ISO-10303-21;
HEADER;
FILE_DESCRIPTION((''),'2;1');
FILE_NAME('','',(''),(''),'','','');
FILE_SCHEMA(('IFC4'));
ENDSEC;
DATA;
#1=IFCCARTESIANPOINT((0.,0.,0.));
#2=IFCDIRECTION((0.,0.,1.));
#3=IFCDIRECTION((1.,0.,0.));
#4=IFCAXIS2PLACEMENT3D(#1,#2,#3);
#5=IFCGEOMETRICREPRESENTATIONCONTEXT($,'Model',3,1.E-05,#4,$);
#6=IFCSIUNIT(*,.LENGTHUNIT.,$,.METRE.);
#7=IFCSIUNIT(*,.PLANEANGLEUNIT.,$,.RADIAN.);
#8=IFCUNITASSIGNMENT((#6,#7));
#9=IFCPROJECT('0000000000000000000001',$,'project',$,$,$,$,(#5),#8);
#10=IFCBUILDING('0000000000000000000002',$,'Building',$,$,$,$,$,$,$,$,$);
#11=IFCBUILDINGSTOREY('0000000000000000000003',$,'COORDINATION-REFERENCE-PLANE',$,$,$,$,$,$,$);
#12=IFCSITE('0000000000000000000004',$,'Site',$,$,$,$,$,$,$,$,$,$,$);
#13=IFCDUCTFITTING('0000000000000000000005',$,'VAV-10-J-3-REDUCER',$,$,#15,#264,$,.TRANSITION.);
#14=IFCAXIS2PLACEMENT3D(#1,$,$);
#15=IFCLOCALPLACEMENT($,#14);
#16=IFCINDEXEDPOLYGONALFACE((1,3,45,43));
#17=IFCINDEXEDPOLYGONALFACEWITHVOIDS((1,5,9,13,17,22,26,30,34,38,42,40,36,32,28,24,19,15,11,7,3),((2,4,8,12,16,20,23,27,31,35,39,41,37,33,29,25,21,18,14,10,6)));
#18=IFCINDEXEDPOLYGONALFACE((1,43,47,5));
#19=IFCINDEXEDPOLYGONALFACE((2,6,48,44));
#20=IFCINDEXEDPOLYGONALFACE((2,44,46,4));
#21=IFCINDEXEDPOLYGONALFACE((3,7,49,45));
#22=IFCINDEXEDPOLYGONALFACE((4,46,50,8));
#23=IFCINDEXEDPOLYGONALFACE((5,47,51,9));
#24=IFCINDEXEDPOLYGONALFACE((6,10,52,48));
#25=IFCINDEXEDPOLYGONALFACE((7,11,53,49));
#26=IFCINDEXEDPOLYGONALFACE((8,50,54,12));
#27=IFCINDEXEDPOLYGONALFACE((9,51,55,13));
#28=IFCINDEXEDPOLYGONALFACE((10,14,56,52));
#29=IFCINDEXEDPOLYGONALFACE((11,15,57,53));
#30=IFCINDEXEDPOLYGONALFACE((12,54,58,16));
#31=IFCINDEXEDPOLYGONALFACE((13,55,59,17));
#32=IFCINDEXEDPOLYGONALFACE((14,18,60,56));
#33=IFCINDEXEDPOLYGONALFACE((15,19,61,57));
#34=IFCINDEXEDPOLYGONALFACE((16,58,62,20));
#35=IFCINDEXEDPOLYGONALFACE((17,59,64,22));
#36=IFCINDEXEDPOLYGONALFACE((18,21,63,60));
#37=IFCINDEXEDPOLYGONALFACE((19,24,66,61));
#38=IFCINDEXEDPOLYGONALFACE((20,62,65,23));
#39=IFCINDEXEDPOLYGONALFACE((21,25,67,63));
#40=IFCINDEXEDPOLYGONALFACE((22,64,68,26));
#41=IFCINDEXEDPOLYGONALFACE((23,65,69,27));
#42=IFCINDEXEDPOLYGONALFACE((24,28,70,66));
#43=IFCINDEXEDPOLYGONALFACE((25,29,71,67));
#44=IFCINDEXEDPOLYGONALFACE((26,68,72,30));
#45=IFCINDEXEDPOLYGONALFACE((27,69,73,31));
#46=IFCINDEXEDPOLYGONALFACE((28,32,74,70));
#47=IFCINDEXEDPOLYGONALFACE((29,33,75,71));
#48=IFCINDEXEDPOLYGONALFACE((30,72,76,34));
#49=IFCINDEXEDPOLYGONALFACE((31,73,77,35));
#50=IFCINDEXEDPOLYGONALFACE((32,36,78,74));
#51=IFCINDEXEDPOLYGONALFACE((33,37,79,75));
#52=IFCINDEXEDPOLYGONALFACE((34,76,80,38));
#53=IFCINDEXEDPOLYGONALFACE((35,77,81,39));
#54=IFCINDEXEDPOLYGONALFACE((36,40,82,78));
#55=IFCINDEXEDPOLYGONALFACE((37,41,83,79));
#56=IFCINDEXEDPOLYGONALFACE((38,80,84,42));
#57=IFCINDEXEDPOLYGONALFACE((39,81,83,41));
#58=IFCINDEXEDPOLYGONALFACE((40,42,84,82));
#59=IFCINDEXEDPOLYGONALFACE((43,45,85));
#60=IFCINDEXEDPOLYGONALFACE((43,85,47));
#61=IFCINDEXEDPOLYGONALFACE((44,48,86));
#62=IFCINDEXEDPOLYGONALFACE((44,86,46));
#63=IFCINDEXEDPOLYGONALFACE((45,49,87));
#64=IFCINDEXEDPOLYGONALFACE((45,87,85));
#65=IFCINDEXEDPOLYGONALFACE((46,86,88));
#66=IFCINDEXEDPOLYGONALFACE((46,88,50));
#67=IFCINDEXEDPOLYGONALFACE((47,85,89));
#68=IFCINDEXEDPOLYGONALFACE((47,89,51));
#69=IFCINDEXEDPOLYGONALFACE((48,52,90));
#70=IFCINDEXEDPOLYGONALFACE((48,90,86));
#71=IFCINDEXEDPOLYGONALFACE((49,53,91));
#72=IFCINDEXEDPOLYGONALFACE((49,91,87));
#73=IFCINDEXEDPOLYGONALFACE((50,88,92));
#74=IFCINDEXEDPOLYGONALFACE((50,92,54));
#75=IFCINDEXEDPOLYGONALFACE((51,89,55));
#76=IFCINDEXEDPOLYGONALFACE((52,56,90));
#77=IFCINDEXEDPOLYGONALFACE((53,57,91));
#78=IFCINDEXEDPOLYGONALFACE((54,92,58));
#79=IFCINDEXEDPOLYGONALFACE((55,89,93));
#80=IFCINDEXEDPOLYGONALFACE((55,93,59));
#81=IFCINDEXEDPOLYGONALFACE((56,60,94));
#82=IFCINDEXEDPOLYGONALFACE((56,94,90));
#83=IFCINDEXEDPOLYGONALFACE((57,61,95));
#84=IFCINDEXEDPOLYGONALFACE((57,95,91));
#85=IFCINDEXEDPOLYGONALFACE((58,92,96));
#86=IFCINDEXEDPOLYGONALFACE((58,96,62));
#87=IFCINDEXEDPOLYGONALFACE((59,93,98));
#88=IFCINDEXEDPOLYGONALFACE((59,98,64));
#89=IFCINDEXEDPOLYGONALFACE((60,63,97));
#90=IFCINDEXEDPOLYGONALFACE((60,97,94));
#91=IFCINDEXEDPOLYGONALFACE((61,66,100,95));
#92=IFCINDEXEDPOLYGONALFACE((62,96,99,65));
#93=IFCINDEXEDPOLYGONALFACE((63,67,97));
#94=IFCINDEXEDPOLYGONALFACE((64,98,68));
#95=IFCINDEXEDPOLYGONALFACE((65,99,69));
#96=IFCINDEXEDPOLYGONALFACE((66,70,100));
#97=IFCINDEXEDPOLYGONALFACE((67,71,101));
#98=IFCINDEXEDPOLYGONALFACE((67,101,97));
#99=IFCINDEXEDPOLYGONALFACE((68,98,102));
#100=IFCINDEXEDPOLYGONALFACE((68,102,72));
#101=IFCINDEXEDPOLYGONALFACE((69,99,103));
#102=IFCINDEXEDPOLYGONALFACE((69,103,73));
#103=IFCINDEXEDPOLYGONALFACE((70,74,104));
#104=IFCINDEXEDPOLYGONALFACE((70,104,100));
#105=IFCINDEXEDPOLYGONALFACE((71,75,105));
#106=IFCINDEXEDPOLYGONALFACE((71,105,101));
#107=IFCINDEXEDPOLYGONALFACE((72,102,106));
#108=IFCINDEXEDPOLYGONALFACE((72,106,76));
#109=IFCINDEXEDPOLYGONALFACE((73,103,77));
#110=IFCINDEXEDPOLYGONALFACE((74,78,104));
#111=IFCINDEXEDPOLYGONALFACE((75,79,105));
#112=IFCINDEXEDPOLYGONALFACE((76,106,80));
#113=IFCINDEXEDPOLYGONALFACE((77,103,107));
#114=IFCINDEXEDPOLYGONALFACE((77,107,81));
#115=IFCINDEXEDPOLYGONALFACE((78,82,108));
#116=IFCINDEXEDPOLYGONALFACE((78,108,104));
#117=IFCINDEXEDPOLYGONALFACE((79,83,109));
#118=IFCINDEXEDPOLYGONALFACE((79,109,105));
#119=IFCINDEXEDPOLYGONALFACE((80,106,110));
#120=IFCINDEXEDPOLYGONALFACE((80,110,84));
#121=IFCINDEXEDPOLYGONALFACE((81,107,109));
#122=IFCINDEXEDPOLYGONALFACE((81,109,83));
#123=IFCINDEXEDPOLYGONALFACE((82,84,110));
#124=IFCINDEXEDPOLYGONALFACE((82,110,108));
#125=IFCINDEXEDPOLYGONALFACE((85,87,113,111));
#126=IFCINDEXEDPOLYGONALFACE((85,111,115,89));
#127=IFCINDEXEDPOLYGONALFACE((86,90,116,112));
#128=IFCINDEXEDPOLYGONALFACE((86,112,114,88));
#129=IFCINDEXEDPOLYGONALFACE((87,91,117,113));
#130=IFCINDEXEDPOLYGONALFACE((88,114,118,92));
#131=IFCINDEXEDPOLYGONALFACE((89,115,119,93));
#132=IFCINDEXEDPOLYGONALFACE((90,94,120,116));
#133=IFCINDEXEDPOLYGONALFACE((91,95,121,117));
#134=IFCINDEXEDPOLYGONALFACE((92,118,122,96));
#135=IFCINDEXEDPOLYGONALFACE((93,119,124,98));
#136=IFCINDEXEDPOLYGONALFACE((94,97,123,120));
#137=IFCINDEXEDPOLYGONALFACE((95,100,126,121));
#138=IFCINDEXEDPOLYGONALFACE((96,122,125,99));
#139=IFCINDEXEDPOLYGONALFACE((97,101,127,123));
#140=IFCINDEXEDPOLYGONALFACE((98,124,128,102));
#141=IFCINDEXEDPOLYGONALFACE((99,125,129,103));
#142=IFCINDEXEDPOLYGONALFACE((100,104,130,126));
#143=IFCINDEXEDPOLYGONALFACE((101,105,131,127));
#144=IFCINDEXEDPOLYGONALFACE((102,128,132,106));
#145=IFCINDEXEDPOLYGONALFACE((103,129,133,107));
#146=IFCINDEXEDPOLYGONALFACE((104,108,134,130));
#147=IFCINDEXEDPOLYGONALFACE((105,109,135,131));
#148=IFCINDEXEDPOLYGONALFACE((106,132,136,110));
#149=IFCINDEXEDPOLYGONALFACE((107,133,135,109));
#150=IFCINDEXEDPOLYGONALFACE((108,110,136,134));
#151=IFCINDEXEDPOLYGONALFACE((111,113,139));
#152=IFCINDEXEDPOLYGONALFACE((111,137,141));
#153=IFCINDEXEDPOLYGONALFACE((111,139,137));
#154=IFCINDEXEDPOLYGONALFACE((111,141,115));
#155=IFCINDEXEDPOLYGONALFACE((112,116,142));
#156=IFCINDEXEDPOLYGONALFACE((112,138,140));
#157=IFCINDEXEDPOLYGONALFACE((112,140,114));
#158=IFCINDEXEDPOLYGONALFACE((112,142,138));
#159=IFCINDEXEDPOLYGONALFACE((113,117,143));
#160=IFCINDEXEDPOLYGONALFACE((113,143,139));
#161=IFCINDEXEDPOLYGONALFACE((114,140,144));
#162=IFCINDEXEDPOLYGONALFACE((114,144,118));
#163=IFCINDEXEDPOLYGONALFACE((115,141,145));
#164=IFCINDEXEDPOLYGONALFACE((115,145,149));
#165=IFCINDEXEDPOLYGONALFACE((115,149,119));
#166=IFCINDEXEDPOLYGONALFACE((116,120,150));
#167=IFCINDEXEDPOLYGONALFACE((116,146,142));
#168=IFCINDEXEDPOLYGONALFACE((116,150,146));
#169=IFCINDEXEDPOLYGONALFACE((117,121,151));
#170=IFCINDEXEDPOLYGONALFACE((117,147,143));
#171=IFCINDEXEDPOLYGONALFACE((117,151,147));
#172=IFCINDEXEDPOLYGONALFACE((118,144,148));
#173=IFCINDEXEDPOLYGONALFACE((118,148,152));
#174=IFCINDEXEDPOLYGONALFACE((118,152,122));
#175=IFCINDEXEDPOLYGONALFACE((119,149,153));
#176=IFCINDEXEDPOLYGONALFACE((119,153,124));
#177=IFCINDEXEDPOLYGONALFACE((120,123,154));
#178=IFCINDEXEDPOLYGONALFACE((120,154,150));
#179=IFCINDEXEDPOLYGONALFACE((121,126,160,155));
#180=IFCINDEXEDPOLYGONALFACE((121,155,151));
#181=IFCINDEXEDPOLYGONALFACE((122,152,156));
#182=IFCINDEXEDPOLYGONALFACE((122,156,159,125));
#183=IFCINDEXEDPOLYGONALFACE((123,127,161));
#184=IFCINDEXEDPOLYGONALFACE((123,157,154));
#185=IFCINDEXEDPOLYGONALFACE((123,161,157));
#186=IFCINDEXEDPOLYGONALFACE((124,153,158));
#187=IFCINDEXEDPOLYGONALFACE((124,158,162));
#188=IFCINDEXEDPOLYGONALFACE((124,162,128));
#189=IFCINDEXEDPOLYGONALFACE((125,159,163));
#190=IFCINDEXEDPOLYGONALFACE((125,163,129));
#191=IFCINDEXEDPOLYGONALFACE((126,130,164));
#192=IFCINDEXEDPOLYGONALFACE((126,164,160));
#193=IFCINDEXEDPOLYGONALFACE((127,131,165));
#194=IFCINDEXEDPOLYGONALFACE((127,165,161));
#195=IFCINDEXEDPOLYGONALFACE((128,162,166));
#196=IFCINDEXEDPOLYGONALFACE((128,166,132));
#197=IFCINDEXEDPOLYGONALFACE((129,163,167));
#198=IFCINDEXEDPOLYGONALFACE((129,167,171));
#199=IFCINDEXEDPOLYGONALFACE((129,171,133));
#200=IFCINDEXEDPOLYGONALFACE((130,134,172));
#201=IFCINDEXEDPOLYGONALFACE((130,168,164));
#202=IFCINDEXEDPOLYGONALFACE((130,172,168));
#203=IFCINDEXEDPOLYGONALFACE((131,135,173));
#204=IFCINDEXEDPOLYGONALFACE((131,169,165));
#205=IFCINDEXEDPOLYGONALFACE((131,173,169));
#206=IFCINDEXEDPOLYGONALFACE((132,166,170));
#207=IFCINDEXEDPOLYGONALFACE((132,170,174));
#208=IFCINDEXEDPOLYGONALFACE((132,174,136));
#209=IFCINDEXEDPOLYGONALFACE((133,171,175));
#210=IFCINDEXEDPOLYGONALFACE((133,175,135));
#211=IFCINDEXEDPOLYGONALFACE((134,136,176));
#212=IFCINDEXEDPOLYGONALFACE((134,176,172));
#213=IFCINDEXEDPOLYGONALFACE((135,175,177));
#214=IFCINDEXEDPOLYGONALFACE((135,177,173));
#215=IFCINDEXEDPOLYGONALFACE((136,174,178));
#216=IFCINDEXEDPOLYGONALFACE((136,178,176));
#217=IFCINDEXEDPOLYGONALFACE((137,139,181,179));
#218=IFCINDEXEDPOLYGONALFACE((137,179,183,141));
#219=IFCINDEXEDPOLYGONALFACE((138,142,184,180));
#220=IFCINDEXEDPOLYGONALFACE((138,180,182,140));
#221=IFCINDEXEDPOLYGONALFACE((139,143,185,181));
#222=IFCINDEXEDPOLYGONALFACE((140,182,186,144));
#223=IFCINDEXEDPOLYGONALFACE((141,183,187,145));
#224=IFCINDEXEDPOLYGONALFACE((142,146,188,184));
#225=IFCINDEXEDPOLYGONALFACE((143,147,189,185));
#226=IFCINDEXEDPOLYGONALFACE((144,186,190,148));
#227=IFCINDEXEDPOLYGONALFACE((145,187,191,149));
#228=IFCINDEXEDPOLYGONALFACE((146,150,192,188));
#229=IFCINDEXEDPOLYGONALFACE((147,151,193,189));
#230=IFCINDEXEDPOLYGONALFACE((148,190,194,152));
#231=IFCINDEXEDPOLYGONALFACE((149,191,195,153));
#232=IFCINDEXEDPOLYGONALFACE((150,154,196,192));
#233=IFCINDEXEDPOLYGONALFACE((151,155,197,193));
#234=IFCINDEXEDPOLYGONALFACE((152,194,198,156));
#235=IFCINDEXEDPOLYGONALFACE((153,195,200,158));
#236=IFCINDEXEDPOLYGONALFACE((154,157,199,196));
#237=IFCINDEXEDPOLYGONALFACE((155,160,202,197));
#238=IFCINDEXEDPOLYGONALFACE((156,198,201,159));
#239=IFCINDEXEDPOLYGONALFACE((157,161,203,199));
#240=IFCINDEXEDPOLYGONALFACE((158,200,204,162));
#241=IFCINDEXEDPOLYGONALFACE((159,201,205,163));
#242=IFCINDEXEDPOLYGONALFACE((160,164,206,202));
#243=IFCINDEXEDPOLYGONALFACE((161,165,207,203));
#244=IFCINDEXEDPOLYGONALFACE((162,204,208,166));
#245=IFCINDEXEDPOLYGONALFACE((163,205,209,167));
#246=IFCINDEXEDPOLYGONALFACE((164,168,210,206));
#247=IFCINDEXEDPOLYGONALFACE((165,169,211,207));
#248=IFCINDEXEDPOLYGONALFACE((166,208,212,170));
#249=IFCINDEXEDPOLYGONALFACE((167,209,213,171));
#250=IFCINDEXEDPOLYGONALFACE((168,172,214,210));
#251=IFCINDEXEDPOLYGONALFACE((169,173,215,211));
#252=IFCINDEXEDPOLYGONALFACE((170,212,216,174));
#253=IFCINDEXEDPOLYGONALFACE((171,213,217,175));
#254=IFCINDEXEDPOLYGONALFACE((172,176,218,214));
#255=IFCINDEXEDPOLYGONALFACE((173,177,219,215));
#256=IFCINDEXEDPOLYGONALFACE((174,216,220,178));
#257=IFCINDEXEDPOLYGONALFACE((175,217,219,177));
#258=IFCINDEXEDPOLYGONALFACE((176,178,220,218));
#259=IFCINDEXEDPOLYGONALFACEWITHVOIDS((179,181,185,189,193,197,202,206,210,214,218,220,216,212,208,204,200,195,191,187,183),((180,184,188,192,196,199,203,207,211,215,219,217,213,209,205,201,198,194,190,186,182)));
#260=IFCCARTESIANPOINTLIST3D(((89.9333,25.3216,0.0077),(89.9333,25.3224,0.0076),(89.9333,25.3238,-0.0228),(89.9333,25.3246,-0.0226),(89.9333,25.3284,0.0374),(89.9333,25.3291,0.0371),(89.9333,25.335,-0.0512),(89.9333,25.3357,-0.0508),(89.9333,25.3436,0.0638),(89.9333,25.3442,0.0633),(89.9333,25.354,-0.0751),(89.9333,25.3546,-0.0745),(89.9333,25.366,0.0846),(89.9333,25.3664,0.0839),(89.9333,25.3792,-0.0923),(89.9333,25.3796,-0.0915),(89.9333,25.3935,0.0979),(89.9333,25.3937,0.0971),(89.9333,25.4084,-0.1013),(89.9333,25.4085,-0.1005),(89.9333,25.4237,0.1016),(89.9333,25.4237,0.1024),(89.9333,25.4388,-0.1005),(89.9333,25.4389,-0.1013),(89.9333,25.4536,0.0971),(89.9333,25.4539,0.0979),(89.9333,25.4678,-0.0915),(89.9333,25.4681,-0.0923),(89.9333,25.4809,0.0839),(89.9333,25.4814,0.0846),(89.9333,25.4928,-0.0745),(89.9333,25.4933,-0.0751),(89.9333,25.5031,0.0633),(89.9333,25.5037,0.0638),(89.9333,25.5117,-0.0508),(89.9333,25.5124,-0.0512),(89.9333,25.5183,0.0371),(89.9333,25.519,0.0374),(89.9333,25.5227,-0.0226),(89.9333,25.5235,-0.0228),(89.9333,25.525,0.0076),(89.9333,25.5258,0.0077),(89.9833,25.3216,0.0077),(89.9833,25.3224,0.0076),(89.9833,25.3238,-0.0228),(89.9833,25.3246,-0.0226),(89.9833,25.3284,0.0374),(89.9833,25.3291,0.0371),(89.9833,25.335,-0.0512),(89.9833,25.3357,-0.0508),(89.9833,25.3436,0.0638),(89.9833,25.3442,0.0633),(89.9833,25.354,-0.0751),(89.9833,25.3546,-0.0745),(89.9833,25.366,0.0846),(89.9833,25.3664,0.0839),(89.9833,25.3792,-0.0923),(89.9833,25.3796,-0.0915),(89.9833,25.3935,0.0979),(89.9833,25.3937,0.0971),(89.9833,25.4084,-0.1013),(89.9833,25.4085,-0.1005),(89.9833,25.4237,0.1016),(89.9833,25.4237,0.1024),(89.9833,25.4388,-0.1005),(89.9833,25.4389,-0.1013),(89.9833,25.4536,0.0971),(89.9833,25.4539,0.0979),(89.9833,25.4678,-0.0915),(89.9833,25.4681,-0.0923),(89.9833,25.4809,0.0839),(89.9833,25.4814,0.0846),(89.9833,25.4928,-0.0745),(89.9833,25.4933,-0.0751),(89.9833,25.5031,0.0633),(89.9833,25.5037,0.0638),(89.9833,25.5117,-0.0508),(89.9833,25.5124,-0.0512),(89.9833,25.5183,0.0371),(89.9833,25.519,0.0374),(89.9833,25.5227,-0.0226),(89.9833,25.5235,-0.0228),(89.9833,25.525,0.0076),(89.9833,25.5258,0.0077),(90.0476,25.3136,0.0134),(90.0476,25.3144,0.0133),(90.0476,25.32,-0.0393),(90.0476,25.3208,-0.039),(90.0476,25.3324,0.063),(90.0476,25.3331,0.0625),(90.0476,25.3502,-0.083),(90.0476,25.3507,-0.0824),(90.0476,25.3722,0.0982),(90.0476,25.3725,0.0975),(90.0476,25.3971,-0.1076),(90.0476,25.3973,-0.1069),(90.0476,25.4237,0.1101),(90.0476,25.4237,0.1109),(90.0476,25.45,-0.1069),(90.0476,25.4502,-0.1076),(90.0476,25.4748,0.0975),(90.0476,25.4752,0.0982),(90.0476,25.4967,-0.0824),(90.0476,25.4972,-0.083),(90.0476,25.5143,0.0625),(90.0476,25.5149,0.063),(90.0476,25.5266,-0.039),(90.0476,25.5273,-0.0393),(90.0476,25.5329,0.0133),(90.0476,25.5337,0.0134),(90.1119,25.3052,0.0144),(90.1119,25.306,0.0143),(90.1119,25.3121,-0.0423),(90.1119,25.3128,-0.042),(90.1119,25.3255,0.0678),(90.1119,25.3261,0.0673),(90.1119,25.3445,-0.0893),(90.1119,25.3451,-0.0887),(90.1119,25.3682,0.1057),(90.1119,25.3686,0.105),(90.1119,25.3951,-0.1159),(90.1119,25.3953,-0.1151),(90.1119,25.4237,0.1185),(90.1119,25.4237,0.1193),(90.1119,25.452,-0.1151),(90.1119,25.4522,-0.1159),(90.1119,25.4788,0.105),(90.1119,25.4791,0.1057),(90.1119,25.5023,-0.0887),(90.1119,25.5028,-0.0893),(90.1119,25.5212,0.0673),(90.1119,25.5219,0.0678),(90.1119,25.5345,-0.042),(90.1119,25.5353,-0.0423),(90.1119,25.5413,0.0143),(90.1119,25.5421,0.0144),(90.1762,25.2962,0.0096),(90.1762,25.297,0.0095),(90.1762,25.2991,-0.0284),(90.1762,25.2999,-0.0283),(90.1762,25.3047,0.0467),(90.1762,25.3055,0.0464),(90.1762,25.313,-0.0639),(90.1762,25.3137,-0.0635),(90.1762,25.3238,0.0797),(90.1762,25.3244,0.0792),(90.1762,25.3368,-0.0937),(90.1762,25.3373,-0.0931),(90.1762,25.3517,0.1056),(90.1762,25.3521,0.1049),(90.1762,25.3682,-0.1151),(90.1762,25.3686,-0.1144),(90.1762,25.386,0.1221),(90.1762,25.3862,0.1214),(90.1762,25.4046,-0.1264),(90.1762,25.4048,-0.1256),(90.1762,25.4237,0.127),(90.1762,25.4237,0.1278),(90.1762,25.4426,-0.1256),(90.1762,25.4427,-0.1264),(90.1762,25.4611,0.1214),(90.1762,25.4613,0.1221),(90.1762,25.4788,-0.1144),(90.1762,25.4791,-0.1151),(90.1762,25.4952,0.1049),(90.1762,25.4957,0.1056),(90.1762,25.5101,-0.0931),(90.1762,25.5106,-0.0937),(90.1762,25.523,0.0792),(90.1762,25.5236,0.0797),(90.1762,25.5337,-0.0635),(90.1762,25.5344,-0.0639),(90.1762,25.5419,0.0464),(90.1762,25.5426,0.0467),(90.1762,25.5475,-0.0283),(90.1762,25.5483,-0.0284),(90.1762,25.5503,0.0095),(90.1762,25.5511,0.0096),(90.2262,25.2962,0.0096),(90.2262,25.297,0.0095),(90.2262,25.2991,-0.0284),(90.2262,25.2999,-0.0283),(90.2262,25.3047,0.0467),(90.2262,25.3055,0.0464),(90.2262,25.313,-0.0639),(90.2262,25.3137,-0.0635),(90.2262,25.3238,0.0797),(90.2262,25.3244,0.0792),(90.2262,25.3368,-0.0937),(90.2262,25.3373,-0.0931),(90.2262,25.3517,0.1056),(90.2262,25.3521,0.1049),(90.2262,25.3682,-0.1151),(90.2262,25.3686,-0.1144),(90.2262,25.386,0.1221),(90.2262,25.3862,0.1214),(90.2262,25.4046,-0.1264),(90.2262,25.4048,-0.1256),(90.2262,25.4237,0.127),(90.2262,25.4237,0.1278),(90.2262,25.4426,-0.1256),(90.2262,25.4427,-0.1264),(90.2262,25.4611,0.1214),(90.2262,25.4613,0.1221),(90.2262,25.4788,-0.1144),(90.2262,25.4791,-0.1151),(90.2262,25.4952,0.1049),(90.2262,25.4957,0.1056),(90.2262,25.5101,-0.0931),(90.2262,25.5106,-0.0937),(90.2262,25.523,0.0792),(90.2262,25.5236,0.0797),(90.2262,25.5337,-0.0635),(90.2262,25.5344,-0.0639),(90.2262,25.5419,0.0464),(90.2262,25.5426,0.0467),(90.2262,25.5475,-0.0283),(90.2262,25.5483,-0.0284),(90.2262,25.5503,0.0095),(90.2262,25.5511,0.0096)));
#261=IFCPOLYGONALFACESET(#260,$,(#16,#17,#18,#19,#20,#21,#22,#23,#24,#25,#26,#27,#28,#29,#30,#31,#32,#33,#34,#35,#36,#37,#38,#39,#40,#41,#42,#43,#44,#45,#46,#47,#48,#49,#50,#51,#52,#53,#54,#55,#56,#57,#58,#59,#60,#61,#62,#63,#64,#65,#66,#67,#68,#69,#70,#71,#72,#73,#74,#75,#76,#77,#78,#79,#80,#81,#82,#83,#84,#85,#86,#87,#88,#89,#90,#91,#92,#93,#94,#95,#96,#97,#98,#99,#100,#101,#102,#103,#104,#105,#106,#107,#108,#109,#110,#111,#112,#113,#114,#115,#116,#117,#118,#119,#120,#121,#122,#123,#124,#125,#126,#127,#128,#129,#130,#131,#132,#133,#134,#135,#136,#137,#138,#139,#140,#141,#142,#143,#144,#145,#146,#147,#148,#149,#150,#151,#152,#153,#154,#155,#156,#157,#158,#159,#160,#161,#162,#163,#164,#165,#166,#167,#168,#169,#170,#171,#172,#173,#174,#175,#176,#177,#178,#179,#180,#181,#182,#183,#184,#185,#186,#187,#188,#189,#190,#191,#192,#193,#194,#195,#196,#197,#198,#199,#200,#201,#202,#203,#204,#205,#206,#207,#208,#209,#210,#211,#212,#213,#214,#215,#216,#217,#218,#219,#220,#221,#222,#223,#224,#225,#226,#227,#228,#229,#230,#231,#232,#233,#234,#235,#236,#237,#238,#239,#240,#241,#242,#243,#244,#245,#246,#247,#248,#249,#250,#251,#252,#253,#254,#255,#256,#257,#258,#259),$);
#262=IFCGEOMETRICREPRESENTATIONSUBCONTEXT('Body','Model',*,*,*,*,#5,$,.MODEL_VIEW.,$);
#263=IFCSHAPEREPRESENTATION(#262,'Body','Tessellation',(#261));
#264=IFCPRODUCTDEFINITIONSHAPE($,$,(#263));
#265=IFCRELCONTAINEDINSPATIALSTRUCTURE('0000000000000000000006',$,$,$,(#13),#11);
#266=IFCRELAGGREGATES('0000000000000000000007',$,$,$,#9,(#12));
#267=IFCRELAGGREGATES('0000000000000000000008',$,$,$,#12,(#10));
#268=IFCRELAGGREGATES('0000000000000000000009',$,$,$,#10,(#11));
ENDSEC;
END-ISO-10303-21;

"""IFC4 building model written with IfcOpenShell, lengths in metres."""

from ifc_helpers import new_model, entity, si_unit, frame, origin_with_axes, place, context, subcontext, project, spatial, element, save


model = new_model("IFC4")

# Units and contexts
model_context_1 = context("Model", 3, precision=1e-05, world=origin_with_axes())
body_context_1 = subcontext(model_context_1, "Body", "Model", "MODEL_VIEW")
ifc_project = project(units=[si_unit("LENGTHUNIT", "METRE"), si_unit("PLANEANGLEUNIT", "RADIAN")], contexts=[model_context_1])

# Site, building, storey
site = spatial("IfcSite", under=ifc_project, Name="Site")
building = spatial("IfcBuilding", under=site, Name="Building")
storey = spatial("IfcBuildingStorey", under=building, Name="COORDINATION-REFERENCE-PLANE")

# Duct fitting
for number, where, z_axis, x_axis, name in (
    (1, (90.2262, 25.4237, 0.0), (0.0, -1.0, 0.0), (0.0, 0.0, 1.0), "VAV-10-J-3-REDUCER"),
):
    element("IfcDuctFitting", number, at=place(None, frame(where, z_axis=z_axis, x_axis=x_axis)), inside=storey, Name=name, PredefinedType="TRANSITION", context=body_context_1, shape_type="SweptSolid", body=[
        entity("IfcRevolvedAreaSolid", entity("IfcArbitraryClosedProfileDef", "AREA", None, entity("IfcPolyline", [entity("IfcCartesianPoint", [0.1278, 0.0]), entity("IfcCartesianPoint", [0.1278, 0.05]), entity("IfcCartesianPoint", [0.1024, 0.2429]), entity("IfcCartesianPoint", [0.1024, 0.2929]), entity("IfcCartesianPoint", [0.1016, 0.2929]), entity("IfcCartesianPoint", [0.1016, 0.2429]), entity("IfcCartesianPoint", [0.127, 0.05]), entity("IfcCartesianPoint", [0.127, 0.0]), entity("IfcCartesianPoint", [0.1278, 0.0])])), entity("IfcAxis2Placement3D", entity("IfcCartesianPoint", [0.0, 0.0, 0.0])), entity("IfcAxis1Placement", entity("IfcCartesianPoint", [0.0, 0.0, 0.0]), entity("IfcDirection", [0.0, 1.0, 0.0])), 6.283185),
    ])

save(model, "model.ifc")
